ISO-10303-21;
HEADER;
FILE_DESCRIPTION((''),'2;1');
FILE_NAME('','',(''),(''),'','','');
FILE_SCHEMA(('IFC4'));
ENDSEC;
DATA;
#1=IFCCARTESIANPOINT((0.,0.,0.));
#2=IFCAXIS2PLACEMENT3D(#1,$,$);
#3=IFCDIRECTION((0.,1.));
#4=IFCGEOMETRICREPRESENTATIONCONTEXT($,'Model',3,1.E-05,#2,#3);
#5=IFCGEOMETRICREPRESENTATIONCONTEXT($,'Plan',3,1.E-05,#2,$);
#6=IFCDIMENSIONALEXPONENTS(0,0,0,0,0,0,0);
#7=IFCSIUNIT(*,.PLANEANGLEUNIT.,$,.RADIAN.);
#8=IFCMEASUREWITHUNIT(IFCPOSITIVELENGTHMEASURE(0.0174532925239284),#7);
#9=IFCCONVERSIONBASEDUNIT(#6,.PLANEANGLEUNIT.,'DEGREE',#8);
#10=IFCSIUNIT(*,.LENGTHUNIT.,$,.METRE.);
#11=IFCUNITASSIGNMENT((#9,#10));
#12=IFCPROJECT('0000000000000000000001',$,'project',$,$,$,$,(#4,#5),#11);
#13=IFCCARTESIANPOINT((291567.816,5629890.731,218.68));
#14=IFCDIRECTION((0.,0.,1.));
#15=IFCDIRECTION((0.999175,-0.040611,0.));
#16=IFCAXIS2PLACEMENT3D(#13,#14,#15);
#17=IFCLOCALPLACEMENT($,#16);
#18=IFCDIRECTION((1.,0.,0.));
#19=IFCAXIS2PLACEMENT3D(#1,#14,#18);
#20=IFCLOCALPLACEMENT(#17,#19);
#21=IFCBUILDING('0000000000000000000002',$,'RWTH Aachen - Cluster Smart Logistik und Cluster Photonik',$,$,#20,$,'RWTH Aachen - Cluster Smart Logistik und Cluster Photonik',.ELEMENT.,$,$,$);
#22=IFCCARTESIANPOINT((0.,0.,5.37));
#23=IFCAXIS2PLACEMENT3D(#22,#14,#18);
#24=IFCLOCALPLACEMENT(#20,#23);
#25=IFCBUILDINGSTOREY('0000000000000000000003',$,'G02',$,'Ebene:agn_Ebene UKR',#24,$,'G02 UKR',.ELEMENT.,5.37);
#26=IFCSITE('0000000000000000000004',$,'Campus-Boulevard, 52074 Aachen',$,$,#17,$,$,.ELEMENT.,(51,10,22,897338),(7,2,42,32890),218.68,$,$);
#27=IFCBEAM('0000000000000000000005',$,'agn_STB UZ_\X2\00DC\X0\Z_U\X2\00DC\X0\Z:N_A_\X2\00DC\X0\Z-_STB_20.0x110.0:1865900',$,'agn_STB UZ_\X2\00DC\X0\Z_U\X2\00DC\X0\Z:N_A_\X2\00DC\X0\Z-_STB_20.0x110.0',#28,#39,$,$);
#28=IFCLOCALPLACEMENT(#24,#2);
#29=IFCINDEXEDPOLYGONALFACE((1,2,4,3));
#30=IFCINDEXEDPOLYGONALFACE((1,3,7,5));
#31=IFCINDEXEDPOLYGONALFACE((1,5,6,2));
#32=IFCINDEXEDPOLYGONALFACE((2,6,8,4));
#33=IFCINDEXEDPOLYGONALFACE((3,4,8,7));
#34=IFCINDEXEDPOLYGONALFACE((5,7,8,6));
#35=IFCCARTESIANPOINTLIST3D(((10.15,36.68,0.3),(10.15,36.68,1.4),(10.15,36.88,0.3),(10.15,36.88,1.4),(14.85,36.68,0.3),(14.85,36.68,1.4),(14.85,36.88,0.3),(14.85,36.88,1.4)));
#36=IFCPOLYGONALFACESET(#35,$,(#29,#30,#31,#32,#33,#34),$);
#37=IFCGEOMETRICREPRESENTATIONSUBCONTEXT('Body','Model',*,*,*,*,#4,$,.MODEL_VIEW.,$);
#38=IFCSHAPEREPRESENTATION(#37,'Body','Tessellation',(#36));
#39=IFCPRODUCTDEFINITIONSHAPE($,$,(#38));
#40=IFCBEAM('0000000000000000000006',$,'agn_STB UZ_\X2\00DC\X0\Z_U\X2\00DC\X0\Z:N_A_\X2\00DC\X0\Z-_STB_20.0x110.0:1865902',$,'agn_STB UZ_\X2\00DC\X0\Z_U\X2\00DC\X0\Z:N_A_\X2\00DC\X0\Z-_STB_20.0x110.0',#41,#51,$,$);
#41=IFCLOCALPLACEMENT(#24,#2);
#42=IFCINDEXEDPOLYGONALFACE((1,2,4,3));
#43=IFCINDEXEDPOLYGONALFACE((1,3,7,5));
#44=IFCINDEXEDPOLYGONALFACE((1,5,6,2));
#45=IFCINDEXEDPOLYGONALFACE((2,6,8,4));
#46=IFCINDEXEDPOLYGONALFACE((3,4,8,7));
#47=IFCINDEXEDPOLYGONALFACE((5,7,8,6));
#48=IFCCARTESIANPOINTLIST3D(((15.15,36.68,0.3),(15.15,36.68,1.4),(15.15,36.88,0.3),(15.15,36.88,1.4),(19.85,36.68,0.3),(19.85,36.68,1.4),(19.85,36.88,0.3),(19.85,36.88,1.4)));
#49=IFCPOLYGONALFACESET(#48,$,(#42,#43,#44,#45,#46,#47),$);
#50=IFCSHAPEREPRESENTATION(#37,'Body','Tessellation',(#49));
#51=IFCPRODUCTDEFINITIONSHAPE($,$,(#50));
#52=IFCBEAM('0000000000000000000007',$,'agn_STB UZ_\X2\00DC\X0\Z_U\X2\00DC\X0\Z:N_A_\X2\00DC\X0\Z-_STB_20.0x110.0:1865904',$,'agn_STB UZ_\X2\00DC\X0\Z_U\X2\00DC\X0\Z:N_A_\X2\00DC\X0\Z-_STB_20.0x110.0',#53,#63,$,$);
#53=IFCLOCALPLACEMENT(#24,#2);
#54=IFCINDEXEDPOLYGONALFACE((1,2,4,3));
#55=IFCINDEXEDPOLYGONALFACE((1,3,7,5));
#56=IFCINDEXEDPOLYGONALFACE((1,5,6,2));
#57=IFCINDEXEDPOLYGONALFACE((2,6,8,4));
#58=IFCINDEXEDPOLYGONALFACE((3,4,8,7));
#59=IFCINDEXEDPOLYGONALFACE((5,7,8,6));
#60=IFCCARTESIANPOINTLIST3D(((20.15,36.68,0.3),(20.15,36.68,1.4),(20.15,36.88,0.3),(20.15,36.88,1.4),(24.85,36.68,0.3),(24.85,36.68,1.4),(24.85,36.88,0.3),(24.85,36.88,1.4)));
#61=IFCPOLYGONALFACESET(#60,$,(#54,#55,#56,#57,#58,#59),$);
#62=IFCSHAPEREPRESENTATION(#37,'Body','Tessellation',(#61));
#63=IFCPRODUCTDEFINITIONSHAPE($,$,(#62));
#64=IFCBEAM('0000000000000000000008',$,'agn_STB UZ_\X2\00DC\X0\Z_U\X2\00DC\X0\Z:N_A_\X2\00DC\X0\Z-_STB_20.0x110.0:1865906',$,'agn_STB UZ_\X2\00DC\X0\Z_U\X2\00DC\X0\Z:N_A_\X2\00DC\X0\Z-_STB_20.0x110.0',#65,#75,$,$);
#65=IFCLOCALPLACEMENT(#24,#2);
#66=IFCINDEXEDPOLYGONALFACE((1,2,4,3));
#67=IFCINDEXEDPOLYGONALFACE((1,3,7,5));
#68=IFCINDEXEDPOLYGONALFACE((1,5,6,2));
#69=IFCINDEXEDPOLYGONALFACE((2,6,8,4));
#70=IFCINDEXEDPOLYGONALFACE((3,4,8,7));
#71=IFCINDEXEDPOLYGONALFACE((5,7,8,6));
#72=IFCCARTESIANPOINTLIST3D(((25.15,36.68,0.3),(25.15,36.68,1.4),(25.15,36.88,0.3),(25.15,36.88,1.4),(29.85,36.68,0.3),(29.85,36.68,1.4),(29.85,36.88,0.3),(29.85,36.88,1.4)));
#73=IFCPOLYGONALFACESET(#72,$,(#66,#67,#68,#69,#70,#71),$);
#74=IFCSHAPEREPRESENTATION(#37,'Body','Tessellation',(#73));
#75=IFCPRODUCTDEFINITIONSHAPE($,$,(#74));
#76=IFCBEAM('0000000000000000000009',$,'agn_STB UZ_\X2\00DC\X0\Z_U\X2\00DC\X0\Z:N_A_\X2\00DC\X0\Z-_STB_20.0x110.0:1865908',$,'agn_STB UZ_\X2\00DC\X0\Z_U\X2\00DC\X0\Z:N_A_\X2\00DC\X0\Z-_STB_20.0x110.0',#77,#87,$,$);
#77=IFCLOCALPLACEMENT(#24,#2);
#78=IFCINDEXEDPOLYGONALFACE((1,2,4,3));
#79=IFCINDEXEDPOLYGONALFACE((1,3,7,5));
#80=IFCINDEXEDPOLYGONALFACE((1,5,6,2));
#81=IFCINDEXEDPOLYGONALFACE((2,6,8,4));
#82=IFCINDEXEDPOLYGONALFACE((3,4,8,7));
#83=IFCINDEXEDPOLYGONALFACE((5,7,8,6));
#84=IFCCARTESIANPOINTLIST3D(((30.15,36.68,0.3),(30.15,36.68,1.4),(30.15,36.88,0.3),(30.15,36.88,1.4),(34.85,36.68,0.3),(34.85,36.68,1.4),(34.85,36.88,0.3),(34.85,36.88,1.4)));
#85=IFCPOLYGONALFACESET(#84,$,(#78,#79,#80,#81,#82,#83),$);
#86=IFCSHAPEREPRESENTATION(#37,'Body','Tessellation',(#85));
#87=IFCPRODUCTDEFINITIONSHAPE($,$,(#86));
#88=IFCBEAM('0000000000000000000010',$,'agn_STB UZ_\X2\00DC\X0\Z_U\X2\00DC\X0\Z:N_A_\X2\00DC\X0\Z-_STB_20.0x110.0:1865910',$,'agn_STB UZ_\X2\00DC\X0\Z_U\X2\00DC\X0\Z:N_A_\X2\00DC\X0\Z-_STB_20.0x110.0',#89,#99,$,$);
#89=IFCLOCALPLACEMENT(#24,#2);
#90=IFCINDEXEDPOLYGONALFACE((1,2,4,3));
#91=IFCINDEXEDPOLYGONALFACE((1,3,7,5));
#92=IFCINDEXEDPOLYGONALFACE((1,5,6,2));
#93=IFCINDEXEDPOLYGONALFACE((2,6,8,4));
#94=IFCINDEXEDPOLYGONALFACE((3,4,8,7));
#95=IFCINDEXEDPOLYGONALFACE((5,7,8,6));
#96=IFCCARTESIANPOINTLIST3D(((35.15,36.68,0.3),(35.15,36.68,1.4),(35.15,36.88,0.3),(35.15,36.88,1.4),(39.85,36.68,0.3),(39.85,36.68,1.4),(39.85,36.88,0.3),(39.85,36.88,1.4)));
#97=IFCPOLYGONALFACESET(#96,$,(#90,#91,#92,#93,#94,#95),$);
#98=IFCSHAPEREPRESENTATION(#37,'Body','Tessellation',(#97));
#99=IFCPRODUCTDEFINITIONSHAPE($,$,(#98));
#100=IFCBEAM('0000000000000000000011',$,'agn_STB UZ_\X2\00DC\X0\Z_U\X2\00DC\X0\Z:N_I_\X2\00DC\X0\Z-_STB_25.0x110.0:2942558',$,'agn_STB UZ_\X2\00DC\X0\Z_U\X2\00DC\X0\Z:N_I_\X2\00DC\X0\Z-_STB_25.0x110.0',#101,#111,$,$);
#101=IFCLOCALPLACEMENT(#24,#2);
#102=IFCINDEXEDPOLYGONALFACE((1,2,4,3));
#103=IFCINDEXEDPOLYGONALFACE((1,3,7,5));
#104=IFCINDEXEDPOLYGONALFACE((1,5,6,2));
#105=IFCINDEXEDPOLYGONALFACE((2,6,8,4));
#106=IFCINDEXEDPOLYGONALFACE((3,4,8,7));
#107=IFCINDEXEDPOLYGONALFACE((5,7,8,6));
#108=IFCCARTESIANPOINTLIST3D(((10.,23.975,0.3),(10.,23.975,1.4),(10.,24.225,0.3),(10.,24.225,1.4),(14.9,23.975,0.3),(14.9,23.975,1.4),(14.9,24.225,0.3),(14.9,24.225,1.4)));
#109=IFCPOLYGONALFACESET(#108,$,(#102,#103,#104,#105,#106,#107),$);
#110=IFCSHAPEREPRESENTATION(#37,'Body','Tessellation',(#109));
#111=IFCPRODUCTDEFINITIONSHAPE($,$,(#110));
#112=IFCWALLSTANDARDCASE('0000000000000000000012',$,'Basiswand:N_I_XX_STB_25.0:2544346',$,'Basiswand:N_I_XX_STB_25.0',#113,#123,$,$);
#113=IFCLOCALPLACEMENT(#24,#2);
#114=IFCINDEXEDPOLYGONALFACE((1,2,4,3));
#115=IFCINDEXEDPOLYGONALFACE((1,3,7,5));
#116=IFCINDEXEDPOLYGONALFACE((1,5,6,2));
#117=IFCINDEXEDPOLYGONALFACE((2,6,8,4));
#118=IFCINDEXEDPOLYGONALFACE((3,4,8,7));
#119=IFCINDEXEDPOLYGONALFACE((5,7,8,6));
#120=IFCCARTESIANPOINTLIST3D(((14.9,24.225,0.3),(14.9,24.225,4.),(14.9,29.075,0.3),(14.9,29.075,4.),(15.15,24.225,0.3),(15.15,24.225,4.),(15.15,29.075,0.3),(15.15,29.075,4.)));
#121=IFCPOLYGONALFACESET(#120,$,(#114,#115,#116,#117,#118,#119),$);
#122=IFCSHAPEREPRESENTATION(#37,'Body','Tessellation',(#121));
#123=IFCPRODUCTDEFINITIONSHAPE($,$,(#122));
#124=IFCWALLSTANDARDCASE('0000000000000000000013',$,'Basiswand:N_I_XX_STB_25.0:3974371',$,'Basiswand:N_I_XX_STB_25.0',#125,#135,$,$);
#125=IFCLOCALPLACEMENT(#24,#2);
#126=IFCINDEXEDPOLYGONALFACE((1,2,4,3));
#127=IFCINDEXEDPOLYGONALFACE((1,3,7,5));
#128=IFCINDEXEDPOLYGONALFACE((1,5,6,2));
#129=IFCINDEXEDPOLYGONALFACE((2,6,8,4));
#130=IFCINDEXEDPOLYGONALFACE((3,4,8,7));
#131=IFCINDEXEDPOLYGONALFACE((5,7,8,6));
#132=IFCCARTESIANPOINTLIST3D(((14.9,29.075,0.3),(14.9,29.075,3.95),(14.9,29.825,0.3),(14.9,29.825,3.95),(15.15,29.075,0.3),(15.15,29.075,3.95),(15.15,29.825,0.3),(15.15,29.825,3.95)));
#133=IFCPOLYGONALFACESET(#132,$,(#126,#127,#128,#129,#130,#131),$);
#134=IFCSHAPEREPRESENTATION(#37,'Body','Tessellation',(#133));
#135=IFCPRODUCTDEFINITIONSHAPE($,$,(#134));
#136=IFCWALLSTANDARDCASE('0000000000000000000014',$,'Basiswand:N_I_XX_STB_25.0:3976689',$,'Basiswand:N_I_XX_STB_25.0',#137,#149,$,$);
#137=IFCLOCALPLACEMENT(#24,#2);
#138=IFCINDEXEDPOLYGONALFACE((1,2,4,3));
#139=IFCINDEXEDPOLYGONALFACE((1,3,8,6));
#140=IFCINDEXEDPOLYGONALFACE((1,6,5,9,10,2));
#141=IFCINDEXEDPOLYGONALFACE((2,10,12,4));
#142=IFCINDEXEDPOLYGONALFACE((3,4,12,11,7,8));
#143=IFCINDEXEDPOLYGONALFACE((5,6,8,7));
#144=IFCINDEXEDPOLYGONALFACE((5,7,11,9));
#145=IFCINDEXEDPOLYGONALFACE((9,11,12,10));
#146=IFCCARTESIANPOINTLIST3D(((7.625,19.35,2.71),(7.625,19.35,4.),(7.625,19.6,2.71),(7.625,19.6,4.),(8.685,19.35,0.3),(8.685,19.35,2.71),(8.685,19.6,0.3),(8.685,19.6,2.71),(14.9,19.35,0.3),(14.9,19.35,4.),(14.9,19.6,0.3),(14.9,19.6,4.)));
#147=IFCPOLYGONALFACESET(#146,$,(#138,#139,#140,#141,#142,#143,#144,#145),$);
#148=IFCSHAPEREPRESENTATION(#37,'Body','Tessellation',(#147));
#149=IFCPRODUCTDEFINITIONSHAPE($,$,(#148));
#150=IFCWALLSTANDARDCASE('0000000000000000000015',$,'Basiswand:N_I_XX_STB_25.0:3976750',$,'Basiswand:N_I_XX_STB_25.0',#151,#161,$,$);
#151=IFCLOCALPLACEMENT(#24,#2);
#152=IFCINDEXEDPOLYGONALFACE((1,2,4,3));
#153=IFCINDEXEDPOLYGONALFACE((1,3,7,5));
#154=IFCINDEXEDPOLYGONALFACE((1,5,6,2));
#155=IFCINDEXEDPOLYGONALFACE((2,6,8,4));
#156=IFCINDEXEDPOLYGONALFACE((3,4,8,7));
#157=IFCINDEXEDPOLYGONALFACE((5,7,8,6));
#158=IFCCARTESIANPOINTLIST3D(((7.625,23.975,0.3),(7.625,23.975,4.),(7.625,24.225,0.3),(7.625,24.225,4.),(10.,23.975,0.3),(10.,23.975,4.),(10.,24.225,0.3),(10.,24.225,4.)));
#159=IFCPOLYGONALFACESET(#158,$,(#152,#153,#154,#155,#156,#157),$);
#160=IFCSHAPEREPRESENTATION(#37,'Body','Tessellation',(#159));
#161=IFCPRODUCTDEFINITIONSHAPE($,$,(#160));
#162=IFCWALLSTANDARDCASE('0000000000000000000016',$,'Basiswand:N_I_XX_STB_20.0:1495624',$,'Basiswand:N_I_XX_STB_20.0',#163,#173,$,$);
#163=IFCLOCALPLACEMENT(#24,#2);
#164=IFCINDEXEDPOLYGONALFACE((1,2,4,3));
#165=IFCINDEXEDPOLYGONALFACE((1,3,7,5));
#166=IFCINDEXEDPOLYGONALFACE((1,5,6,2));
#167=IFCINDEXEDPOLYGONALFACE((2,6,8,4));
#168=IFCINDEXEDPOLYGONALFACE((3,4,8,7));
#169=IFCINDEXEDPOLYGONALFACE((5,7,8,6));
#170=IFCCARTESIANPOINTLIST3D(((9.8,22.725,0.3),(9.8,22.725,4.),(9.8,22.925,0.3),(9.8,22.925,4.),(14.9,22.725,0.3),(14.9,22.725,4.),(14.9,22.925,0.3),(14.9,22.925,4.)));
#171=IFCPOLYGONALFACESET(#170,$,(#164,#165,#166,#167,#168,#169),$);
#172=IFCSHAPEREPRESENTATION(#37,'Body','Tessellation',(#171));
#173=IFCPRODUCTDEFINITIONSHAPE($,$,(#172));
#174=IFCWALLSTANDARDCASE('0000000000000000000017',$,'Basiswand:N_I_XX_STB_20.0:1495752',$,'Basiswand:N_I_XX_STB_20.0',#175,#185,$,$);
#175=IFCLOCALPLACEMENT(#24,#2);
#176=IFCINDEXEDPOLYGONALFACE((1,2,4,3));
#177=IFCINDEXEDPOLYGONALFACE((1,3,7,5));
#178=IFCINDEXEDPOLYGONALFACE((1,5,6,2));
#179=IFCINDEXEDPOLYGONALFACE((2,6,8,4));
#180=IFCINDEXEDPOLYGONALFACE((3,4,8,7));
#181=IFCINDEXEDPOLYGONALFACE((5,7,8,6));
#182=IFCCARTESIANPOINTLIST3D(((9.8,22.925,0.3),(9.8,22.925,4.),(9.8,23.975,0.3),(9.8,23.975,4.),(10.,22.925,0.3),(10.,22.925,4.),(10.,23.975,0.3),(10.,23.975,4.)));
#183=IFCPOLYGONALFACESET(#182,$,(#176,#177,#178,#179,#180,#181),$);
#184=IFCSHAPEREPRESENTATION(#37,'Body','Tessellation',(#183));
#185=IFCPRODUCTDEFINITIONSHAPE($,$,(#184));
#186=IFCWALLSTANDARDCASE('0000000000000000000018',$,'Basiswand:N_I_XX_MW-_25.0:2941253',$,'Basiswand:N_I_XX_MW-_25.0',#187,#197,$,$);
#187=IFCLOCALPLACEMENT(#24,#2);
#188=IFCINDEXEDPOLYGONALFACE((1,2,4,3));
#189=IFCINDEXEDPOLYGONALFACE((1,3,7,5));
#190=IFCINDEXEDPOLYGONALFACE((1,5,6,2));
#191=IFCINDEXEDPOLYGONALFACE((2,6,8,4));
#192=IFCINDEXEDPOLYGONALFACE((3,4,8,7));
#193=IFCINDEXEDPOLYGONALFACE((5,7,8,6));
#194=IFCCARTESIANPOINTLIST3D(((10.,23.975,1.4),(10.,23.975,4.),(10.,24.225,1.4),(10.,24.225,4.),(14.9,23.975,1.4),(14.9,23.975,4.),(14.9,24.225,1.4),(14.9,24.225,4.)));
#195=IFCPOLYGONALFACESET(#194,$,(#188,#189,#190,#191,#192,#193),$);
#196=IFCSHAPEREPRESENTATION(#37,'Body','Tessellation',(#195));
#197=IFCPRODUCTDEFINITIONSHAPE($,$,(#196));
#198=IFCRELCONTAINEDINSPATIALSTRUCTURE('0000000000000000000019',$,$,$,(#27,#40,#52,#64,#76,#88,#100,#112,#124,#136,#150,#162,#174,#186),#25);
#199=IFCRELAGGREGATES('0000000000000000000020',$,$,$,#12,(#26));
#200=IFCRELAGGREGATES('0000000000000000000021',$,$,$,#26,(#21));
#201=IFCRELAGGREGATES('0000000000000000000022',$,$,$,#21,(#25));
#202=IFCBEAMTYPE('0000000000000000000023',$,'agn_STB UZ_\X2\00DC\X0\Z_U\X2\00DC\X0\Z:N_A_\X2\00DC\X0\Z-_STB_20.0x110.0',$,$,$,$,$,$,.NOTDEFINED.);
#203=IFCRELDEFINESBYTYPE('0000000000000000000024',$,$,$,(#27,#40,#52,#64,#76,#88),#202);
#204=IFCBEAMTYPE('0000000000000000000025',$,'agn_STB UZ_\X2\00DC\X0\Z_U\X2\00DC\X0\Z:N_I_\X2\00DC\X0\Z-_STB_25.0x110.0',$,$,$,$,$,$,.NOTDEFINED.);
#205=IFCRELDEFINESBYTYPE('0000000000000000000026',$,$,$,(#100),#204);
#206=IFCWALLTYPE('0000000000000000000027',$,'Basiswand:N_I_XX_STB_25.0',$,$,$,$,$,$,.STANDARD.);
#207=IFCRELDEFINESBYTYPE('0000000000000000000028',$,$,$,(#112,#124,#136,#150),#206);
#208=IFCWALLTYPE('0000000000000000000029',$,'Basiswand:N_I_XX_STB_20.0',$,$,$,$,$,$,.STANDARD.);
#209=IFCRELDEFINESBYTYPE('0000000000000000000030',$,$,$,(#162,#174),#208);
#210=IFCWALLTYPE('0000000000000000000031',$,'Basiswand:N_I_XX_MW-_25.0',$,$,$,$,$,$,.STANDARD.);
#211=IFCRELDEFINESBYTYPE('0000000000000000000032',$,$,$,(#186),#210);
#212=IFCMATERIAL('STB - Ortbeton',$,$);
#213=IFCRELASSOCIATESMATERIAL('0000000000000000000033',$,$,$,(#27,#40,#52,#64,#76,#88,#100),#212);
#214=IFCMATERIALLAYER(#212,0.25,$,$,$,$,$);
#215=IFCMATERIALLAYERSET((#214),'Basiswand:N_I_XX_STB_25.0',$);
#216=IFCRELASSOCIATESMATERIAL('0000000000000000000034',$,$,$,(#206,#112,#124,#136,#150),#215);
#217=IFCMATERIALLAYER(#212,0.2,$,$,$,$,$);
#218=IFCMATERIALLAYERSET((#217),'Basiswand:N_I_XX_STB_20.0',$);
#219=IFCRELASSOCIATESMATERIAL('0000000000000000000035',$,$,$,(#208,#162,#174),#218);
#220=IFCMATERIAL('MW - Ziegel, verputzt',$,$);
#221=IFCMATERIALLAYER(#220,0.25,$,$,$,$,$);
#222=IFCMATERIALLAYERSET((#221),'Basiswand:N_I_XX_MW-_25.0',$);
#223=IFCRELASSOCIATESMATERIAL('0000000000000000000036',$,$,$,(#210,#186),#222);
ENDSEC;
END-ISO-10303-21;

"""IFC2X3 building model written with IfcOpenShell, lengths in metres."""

from ifc_helpers import new_model, entity, si_unit, converted_unit, direction, frame, frame_2d, origin, origin_with_axes, place, context, subcontext, project, spatial, rectangle, extrude, material, layer, layer_set, layer_usage, type_object, element, save


model = new_model("IFC2X3")

# Units and contexts
model_context = context("Model", 3, precision=1e-05, world=origin(), true_north=direction((0.0, 1.0)))
plan_context = context("Plan", 3, precision=1e-05, world=origin())
body_context = subcontext(model_context, "Body", "Model", "MODEL_VIEW")
ifc_project = project(units=[converted_unit("PLANEANGLEUNIT", "DEGREE", entity("IfcPositiveLengthMeasure", 0.0174532925239284), si_unit("PLANEANGLEUNIT", "RADIAN"), dimensions=[0, 0, 0, 0, 0, 0, 0]), si_unit("LENGTHUNIT", "METRE")], contexts=[model_context, plan_context])

# Site, building, storey
site_placement = place(None, frame((291567.816, 5629890.731, 218.68), z_axis=(0.0, 0.0, 1.0), x_axis=(0.999175, -0.040611, 0.0)))
site = spatial("IfcSite", under=ifc_project, at=site_placement, Name="Campus-Boulevard, 52074 Aachen", CompositionType="ELEMENT", RefLatitude=(51, 10, 22, 897338), RefLongitude=(7, 2, 42, 32890), RefElevation=218.68)
building_placement = place(site_placement, origin_with_axes())
building = spatial("IfcBuilding", under=site, at=building_placement, Name="RWTH Aachen - Cluster Smart Logistik und Cluster Photonik", LongName="RWTH Aachen - Cluster Smart Logistik und Cluster Photonik", CompositionType="ELEMENT")
storey_placement = place(building_placement, frame((0.0, 0.0, 5.37), z_axis=(0.0, 0.0, 1.0), x_axis=(1.0, 0.0, 0.0)))
storey = spatial("IfcBuildingStorey", under=building, at=storey_placement, Name="G02", ObjectType="Ebene:agn_Ebene UKR", LongName="G02 UKR", CompositionType="ELEMENT", Elevation=5.37)

# Beams
ifc_material_1 = material(Name="STB - Ortbeton")
beam_type_1 = type_object("IfcBeamType", Name="agn_STB UZ_ÜZ_UÜZ:N_A_ÜZ-_STB_20.0x110.0", PredefinedType="NOTDEFINED")
for number, where, z_axis, x_axis, name in (
    (1, (10.15, 36.78, 0.3), (0.0, 0.0, 1.0), (1.0, 0.0, 0.0), "agn_STB UZ_ÜZ_UÜZ:N_A_ÜZ-_STB_20.0x110.0:1865900"),
    (2, (15.15, 36.78, 0.3), (0.0, 0.0, 1.0), (1.0, 0.0, 0.0), "agn_STB UZ_ÜZ_UÜZ:N_A_ÜZ-_STB_20.0x110.0:1865902"),
    (3, (20.15, 36.78, 0.3), (0.0, 0.0, 1.0), (1.0, 0.0, 0.0), "agn_STB UZ_ÜZ_UÜZ:N_A_ÜZ-_STB_20.0x110.0:1865904"),
    (4, (25.15, 36.78, 0.3), (0.0, 0.0, 1.0), (1.0, 0.0, 0.0), "agn_STB UZ_ÜZ_UÜZ:N_A_ÜZ-_STB_20.0x110.0:1865906"),
    (5, (30.15, 36.78, 0.3), (0.0, 0.0, 1.0), (1.0, 0.0, 0.0), "agn_STB UZ_ÜZ_UÜZ:N_A_ÜZ-_STB_20.0x110.0:1865908"),
    (6, (35.15, 36.78, 0.3), (0.0, 0.0, 1.0), (1.0, 0.0, 0.0), "agn_STB UZ_ÜZ_UÜZ:N_A_ÜZ-_STB_20.0x110.0:1865910"),
):
    element("IfcBeam", number, at=place(storey_placement, frame(where, z_axis=z_axis, x_axis=x_axis)), inside=storey, type_object=beam_type_1, material=ifc_material_1, Name=name, ObjectType="agn_STB UZ_ÜZ_UÜZ:N_A_ÜZ-_STB_20.0x110.0", context=body_context, shape_type="SweptSolid", body=[
        extrude(rectangle(XDim=1.1, YDim=0.2, at=frame_2d((0.0, 0.0), x_axis=(1.0, 0.0))), frame((0.0, 0.0, 0.55), z_axis=(1.0, 0.0, 0.0), x_axis=(0.0, 0.0, -1.0)), (0.0, 0.0, 1.0), 4.7),
    ])
beam_type_2 = type_object("IfcBeamType", Name="agn_STB UZ_ÜZ_UÜZ:N_I_ÜZ-_STB_25.0x110.0", PredefinedType="NOTDEFINED")
beam_1_placement = place(storey_placement, frame((15.025, 24.1, 0.3), z_axis=(0.0, 0.0, 1.0), x_axis=(-1.0, 0.0, 0.0)))
element("IfcBeam", 7, at=beam_1_placement, inside=storey, type_object=beam_type_2, material=ifc_material_1, Name="agn_STB UZ_ÜZ_UÜZ:N_I_ÜZ-_STB_25.0x110.0:2942558", ObjectType="agn_STB UZ_ÜZ_UÜZ:N_I_ÜZ-_STB_25.0x110.0", context=body_context, shape_type="SweptSolid", body=[
    extrude(rectangle(XDim=1.1, YDim=0.25, at=frame_2d((0.0, 0.0), x_axis=(1.0, 0.0))), frame((0.125, 0.0, 0.55), z_axis=(1.0, 0.0, 0.0), x_axis=(0.0, 0.0, -1.0)), (0.0, 0.0, 1.0), 4.9),
])

# Walls
ifc_layer_1 = layer(ifc_material_1, 0.25)
ifc_layer_set_1 = layer_set([ifc_layer_1], Name="Basiswand:N_I_XX_STB_25.0")
ifc_layer_usage_1 = layer_usage(ifc_layer_set_1, "AXIS2", "NEGATIVE", 0.125)
wall_type_1 = type_object("IfcWallType", Name="Basiswand:N_I_XX_STB_25.0", PredefinedType="STANDARD", material=ifc_layer_set_1)
wall_1_placement = place(storey_placement, frame((15.025, 24.225, 0.3), z_axis=(0.0, 0.0, 1.0), x_axis=(0.0, 1.0, 0.0)))
element("IfcWallStandardCase", 8, at=wall_1_placement, inside=storey, type_object=wall_type_1, material=ifc_layer_usage_1, Name="Basiswand:N_I_XX_STB_25.0:2544346", ObjectType="Basiswand:N_I_XX_STB_25.0", context=body_context, shape_type="SweptSolid", body=[
    extrude(rectangle(XDim=4.85, YDim=0.25, at=frame_2d((2.425, 0.0), x_axis=(-1.0, 0.0))), origin(), (0.0, 0.0, 1.0), 3.7),
])
ifc_layer_usage_2 = layer_usage(ifc_layer_set_1, "AXIS2", "NEGATIVE", 0.125)
wall_2_placement = place(storey_placement, frame((15.025, 29.075, 0.3), z_axis=(0.0, 0.0, 1.0), x_axis=(0.0, 1.0, 0.0)))
element("IfcWallStandardCase", 9, at=wall_2_placement, inside=storey, type_object=wall_type_1, material=ifc_layer_usage_2, Name="Basiswand:N_I_XX_STB_25.0:3974371", ObjectType="Basiswand:N_I_XX_STB_25.0", context=body_context, shape_type="SweptSolid", body=[
    extrude(rectangle(XDim=0.75, YDim=0.25, at=frame_2d((0.375, 0.0), x_axis=(-1.0, 0.0))), origin(), (0.0, 0.0, 1.0), 3.65),
])

# Wall, opening
ifc_layer_usage_3 = layer_usage(ifc_layer_set_1, "AXIS2", "NEGATIVE", 0.125)
wall_3_placement = place(storey_placement, frame((7.625, 19.475, 0.3), z_axis=(0.0, 0.0, 1.0), x_axis=(1.0, 0.0, 0.0)))
wall_3 = element("IfcWallStandardCase", 10, at=wall_3_placement, inside=storey, type_object=wall_type_1, material=ifc_layer_usage_3, Name="Basiswand:N_I_XX_STB_25.0:3976689", ObjectType="Basiswand:N_I_XX_STB_25.0", context=body_context, shape_type="SweptSolid", body=[
    extrude(rectangle(XDim=7.275, YDim=0.25, at=frame_2d((3.6375, 0.0), x_axis=(-1.0, 0.0))), origin(), (0.0, 0.0, 1.0), 3.7),
])
opening_placement = place(wall_3_placement, frame((-0.3, -0.125, 0.0), z_axis=(0.0, 0.0, 1.0), x_axis=(1.0, 0.0, 0.0)))
element("IfcOpeningElement", 11, at=opening_placement, cuts=wall_3, ObjectType="Opening", context=body_context, shape_type="SweptSolid", body=[
    extrude(rectangle(XDim=2.41, YDim=1.36, at=frame_2d((1.205, 0.68), x_axis=(1.0, 0.0))), frame((0.0, 0.0, 0.0), z_axis=(0.0, 1.0, 0.0), x_axis=(0.0, 0.0, 1.0)), (0.0, 0.0, 1.0), 0.25),
])

# Walls
ifc_layer_usage_4 = layer_usage(ifc_layer_set_1, "AXIS2", "NEGATIVE", 0.125)
wall_4_placement = place(storey_placement, frame((7.625, 24.1, 0.3), z_axis=(0.0, 0.0, 1.0), x_axis=(1.0, 0.0, 0.0)))
element("IfcWallStandardCase", 12, at=wall_4_placement, inside=storey, type_object=wall_type_1, material=ifc_layer_usage_4, Name="Basiswand:N_I_XX_STB_25.0:3976750", ObjectType="Basiswand:N_I_XX_STB_25.0", context=body_context, shape_type="SweptSolid", body=[
    extrude(rectangle(XDim=2.375, YDim=0.25, at=frame_2d((1.1875, 0.0), x_axis=(-1.0, 0.0))), origin(), (0.0, 0.0, 1.0), 3.7),
])
ifc_layer_2 = layer(ifc_material_1, 0.2)
ifc_layer_set_2 = layer_set([ifc_layer_2], Name="Basiswand:N_I_XX_STB_20.0")
ifc_layer_usage_5 = layer_usage(ifc_layer_set_2, "AXIS2", "NEGATIVE", 0.1)
wall_type_2 = type_object("IfcWallType", Name="Basiswand:N_I_XX_STB_20.0", PredefinedType="STANDARD", material=ifc_layer_set_2)
wall_5_placement = place(storey_placement, frame((14.9, 22.825, 0.3), z_axis=(0.0, 0.0, 1.0), x_axis=(-1.0, 0.0, 0.0)))
element("IfcWallStandardCase", 13, at=wall_5_placement, inside=storey, type_object=wall_type_2, material=ifc_layer_usage_5, Name="Basiswand:N_I_XX_STB_20.0:1495624", ObjectType="Basiswand:N_I_XX_STB_20.0", context=body_context, shape_type="SweptSolid", body=[
    extrude(rectangle(XDim=5.1, YDim=0.2, at=frame_2d((2.55, 0.0), x_axis=(-1.0, 0.0))), origin(), (0.0, 0.0, 1.0), 3.7),
])
ifc_layer_usage_6 = layer_usage(ifc_layer_set_2, "AXIS2", "NEGATIVE", 0.1)
wall_6_placement = place(storey_placement, frame((9.9, 23.975, 0.3), z_axis=(0.0, 0.0, 1.0), x_axis=(0.0, -1.0, 0.0)))
element("IfcWallStandardCase", 14, at=wall_6_placement, inside=storey, type_object=wall_type_2, material=ifc_layer_usage_6, Name="Basiswand:N_I_XX_STB_20.0:1495752", ObjectType="Basiswand:N_I_XX_STB_20.0", context=body_context, shape_type="SweptSolid", body=[
    extrude(rectangle(XDim=1.05, YDim=0.2, at=frame_2d((0.525, 0.0), x_axis=(-1.0, 0.0))), origin(), (0.0, 0.0, 1.0), 3.7),
])
ifc_material_2 = material(Name="MW - Ziegel, verputzt")
ifc_layer_3 = layer(ifc_material_2, 0.25)
ifc_layer_set_3 = layer_set([ifc_layer_3], Name="Basiswand:N_I_XX_MW-_25.0")
ifc_layer_usage_7 = layer_usage(ifc_layer_set_3, "AXIS2", "NEGATIVE", 0.125)
wall_type_3 = type_object("IfcWallType", Name="Basiswand:N_I_XX_MW-_25.0", PredefinedType="STANDARD", material=ifc_layer_set_3)
wall_7_placement = place(storey_placement, frame((10.0, 24.1, 1.4), z_axis=(0.0, 0.0, 1.0), x_axis=(1.0, 0.0, 0.0)))
element("IfcWallStandardCase", 15, at=wall_7_placement, inside=storey, type_object=wall_type_3, material=ifc_layer_usage_7, Name="Basiswand:N_I_XX_MW-_25.0:2941253", ObjectType="Basiswand:N_I_XX_MW-_25.0", context=body_context, shape_type="SweptSolid", body=[
    extrude(rectangle(XDim=4.9, YDim=0.25, at=frame_2d((2.45, 0.0), x_axis=(-1.0, 0.0))), origin(), (0.0, 0.0, 1.0), 2.6),
])

save(model, "model.ifc")
